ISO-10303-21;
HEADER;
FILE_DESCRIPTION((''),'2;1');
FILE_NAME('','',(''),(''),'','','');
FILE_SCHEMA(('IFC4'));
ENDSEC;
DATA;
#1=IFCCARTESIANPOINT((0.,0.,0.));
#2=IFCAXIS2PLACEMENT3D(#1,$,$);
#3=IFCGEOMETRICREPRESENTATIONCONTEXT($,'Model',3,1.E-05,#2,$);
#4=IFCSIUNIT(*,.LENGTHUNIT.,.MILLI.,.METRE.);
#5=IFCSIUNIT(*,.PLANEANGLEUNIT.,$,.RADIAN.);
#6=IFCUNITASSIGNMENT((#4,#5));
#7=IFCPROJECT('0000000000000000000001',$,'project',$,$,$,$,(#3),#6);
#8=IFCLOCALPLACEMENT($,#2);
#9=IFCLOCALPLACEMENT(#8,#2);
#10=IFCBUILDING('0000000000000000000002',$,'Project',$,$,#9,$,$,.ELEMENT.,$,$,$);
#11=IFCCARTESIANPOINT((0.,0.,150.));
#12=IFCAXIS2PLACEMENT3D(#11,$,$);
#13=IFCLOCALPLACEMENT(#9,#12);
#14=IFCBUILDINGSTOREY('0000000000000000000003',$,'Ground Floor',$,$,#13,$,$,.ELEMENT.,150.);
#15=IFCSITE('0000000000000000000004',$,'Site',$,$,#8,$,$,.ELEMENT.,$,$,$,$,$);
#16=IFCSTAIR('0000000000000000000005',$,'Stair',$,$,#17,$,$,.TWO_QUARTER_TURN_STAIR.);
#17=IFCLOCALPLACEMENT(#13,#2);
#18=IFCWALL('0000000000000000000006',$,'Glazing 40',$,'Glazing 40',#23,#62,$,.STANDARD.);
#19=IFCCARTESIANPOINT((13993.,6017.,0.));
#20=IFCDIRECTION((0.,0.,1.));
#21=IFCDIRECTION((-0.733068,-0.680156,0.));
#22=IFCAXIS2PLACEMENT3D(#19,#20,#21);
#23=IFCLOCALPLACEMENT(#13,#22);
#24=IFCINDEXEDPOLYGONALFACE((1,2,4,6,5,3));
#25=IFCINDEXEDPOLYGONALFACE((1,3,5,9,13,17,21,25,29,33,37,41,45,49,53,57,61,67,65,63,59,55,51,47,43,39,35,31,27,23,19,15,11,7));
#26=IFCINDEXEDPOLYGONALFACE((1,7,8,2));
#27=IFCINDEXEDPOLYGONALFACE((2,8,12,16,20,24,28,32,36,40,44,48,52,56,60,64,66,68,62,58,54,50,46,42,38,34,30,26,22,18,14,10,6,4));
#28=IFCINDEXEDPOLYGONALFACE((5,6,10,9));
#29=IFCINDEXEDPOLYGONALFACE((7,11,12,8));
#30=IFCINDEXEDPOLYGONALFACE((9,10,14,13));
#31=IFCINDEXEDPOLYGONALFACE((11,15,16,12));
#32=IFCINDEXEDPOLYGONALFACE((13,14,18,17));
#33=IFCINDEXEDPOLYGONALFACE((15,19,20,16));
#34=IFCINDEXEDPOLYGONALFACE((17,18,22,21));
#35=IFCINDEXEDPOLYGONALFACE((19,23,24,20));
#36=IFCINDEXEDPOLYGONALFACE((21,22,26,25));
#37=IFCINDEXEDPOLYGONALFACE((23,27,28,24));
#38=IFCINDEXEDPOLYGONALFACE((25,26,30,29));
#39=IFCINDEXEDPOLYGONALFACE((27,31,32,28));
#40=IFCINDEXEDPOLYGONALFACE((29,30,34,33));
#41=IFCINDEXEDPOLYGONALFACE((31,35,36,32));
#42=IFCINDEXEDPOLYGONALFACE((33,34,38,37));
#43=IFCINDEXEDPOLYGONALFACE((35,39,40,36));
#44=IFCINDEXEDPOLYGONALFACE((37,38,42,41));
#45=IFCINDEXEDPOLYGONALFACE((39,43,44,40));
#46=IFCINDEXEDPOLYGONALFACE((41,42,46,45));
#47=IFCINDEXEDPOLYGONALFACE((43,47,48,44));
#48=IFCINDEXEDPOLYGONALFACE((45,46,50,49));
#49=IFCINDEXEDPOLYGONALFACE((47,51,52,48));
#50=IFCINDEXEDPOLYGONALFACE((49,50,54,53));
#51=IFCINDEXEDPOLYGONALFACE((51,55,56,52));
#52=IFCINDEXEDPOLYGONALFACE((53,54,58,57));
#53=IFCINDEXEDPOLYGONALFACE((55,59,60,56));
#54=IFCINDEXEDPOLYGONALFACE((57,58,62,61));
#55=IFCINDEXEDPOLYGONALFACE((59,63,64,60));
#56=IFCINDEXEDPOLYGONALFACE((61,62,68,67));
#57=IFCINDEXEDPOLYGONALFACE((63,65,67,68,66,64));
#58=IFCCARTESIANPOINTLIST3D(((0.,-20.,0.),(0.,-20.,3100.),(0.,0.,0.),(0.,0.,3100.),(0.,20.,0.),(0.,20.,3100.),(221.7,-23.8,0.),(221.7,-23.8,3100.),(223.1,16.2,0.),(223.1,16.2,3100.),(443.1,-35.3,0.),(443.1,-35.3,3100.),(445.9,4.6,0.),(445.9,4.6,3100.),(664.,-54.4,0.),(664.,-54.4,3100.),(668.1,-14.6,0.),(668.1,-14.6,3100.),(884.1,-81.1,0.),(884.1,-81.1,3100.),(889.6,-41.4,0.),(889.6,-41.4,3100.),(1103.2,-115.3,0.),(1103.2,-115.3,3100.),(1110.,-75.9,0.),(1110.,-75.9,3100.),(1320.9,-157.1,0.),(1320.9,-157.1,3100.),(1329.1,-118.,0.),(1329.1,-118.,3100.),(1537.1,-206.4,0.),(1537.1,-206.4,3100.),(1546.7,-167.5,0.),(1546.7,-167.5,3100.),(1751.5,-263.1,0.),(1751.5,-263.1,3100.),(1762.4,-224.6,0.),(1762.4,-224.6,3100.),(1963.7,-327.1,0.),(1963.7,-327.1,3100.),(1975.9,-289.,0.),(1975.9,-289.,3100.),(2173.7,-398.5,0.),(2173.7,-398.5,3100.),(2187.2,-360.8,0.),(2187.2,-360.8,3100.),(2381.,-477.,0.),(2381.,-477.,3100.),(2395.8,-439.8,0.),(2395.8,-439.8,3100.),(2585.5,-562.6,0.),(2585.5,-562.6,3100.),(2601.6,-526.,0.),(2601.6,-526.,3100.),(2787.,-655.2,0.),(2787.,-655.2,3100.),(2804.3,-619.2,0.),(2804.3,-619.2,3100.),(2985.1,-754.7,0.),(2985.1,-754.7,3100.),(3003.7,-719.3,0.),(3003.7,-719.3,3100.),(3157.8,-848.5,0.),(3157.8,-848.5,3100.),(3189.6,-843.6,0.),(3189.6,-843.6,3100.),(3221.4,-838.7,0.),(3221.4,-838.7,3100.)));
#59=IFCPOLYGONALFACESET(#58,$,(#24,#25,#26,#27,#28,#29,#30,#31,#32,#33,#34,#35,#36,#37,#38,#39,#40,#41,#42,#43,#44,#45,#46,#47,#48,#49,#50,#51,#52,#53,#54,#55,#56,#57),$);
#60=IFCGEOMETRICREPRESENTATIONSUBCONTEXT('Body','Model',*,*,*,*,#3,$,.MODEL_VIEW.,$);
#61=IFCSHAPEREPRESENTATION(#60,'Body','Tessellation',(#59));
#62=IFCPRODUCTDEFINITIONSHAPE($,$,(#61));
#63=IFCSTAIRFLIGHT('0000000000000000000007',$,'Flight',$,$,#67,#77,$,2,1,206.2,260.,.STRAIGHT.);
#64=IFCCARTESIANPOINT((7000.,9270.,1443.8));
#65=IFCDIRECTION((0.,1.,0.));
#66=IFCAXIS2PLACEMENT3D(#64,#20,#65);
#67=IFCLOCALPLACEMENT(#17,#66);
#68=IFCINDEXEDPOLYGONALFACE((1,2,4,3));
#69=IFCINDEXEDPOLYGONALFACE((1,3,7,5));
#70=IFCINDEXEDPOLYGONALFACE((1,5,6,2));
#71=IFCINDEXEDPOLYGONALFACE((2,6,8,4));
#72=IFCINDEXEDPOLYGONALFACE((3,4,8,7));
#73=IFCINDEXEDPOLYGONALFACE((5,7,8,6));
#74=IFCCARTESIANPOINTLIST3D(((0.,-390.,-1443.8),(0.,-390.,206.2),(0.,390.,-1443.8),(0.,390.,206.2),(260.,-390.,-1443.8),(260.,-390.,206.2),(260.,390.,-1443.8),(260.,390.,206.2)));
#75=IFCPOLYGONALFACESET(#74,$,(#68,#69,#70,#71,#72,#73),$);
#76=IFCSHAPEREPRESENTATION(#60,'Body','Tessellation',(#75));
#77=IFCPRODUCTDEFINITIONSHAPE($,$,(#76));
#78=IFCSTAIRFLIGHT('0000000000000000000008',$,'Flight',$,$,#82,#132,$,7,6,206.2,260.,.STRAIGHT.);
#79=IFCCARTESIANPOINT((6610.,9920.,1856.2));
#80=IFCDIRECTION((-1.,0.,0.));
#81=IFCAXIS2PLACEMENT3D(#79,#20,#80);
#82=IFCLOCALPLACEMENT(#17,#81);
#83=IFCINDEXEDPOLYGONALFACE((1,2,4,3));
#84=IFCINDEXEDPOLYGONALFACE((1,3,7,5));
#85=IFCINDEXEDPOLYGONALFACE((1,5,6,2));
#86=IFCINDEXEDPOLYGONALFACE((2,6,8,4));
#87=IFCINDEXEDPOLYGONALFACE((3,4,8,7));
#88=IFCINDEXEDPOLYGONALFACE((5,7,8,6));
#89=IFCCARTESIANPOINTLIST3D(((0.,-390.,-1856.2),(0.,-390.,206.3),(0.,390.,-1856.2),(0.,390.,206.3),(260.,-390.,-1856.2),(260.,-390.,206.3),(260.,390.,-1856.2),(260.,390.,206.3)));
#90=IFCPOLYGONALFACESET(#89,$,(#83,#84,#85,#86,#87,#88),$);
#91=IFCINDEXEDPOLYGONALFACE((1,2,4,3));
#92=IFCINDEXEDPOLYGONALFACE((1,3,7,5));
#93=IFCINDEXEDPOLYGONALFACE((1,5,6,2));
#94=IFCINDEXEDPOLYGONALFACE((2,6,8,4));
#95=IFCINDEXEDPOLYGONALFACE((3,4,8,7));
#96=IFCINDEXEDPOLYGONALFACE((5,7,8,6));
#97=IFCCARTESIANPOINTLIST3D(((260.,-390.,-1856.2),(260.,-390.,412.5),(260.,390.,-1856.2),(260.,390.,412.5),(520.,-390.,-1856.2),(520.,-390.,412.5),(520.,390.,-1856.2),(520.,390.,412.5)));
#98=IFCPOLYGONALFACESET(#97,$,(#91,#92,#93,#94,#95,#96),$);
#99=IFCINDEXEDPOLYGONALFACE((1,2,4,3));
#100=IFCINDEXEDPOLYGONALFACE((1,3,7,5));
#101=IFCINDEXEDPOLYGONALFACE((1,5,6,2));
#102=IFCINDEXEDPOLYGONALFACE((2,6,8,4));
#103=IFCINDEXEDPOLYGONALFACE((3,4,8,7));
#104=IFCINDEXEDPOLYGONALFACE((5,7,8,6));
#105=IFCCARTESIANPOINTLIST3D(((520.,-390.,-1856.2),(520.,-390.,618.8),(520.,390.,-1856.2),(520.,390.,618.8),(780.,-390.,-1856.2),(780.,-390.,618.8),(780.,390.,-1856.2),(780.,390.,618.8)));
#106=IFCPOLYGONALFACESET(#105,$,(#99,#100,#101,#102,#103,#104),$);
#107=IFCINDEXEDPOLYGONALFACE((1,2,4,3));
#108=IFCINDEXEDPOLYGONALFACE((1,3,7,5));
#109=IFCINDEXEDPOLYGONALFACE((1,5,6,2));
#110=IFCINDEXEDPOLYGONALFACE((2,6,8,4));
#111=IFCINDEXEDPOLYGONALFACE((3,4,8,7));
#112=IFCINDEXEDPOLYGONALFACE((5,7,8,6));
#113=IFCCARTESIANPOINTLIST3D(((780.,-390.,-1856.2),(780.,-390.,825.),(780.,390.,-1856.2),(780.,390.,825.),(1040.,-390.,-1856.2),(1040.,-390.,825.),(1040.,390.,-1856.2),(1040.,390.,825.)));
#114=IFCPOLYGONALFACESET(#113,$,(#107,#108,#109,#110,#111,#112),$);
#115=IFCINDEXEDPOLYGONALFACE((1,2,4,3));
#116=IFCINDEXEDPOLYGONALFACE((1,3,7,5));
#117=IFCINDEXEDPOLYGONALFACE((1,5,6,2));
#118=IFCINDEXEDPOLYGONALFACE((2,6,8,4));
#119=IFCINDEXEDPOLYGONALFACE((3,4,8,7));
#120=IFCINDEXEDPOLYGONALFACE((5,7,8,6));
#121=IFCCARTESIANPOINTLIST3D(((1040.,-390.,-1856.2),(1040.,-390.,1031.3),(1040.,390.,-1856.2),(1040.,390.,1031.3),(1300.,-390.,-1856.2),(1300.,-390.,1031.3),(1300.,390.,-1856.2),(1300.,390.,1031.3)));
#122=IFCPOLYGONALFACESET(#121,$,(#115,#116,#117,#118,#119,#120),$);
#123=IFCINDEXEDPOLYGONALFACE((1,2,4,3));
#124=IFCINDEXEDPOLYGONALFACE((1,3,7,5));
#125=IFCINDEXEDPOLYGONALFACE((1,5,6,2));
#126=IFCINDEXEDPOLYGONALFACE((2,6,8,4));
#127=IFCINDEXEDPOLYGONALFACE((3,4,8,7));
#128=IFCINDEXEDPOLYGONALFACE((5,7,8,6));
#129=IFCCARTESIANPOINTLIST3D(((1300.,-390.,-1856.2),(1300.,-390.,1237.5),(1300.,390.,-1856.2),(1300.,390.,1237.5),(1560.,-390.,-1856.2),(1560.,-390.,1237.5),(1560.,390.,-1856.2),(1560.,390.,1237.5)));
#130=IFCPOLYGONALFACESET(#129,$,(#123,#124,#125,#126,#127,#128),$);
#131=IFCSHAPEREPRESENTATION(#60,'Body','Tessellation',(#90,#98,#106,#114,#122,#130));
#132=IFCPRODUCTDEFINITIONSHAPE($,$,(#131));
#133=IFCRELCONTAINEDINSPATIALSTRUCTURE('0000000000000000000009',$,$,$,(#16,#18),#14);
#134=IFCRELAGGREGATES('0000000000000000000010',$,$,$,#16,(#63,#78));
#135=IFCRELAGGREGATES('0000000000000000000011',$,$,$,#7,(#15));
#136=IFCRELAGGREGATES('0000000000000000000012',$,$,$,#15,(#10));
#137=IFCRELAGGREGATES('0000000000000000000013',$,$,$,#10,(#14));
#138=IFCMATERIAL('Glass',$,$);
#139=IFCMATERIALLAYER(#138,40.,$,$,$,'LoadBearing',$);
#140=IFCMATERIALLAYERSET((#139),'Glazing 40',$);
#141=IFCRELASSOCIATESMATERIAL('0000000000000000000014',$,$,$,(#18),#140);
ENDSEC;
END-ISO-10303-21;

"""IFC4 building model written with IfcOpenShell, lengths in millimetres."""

from ifc_helpers import new_model, si_unit, frame, frame_2d, origin, place, context, subcontext, project, spatial, polyline, rectangle, outline, extrude, material, layer, layer_set, layer_usage, element, aggregate, save


model = new_model("IFC4")

# Units and contexts
model_context = context("Model", 3, precision=1e-05, world=origin())
body_context = subcontext(model_context, "Body", "Model", "MODEL_VIEW")
ifc_project = project(units=[si_unit("LENGTHUNIT", "METRE", prefix="MILLI"), si_unit("PLANEANGLEUNIT", "RADIAN")], contexts=[model_context])

# Site, building, storey
site_placement = place(None, origin())
site = spatial("IfcSite", under=ifc_project, at=site_placement, Name="Site", CompositionType="ELEMENT")
building_placement = place(site_placement, origin())
building = spatial("IfcBuilding", under=site, at=building_placement, Name="Project", CompositionType="ELEMENT")
storey_placement = place(building_placement, frame((0.0, 0.0, 150.0)))
storey = spatial("IfcBuildingStorey", under=building, at=storey_placement, Name="Ground Floor", CompositionType="ELEMENT", Elevation=150.0)

# Stair
stair_placement = place(storey_placement, origin())
stair = element("IfcStair", 1, at=stair_placement, inside=storey, Name="Stair", PredefinedType="TWO_QUARTER_TURN_STAIR")

# Wall
ifc_material_1 = material(Name="Glass")
ifc_layer_1 = layer(ifc_material_1, 40.0, Category="LoadBearing")
ifc_layer_set_1 = layer_set([ifc_layer_1], Name="Glazing 40")
ifc_layer_usage_1 = layer_usage(ifc_layer_set_1, "AXIS2", "NEGATIVE", 20.0)
wall_1_placement = place(storey_placement, frame((13993.0, 6017.0, 0.0), z_axis=(0.0, 0.0, 1.0), x_axis=(-0.733068, -0.680156, 0.0)))
element("IfcWall", 2, at=wall_1_placement, inside=storey, material=ifc_layer_usage_1, Name="Glazing 40", ObjectType="Glazing 40", PredefinedType="STANDARD", context=body_context, shape_type="SweptSolid", body=[
    extrude(outline(polyline([(0.0, -20.0), (0.0, 0.0), (0.0, 20.0), (223.1, 16.2), (445.9, 4.6), (668.1, -14.6), (889.6, -41.4), (1110.0, -75.9), (1329.1, -118.0), (1546.7, -167.5), (1762.4, -224.6), (1975.9, -289.0), (2187.2, -360.8), (2395.8, -439.8), (2601.6, -526.0), (2804.3, -619.2), (3003.7, -719.3), (3221.4, -838.7), (3189.6, -843.6), (3157.8, -848.5), (2985.1, -754.7), (2787.0, -655.2), (2585.5, -562.6), (2381.0, -477.0), (2173.7, -398.5), (1963.7, -327.1), (1751.5, -263.1), (1537.1, -206.4), (1320.9, -157.1), (1103.2, -115.3), (884.1, -81.1), (664.0, -54.4), (443.1, -35.3), (221.7, -23.8), (0.0, -20.0)])), origin(), (0.0, 0.0, 1.0), 3100.0),
])

# Stair flights
stair_flight_1_placement = place(stair_placement, frame((7000.0, 9270.0, 1443.8), z_axis=(0.0, 0.0, 1.0), x_axis=(0.0, 1.0, 0.0)))
stair_flight_1 = element("IfcStairFlight", 3, at=stair_flight_1_placement, Name="Flight", NumberOfRisers=2, NumberOfTreads=1, PredefinedType="STRAIGHT", RiserHeight=206.2, TreadLength=260.0, context=body_context, shape_type="SweptSolid", body=[
    extrude(rectangle(XDim=260.0, YDim=780.0, at=frame_2d((130.0, 0.0))), frame((0.0, 0.0, -1443.8)), (0.0, 0.0, 1.0), 1650.0),
])
stair_flight_2_placement = place(stair_placement, frame((6610.0, 9920.0, 1856.2), z_axis=(0.0, 0.0, 1.0), x_axis=(-1.0, 0.0, 0.0)))
stair_flight_2 = element("IfcStairFlight", 4, at=stair_flight_2_placement, Name="Flight", NumberOfRisers=7, NumberOfTreads=6, PredefinedType="STRAIGHT", RiserHeight=206.2, TreadLength=260.0, context=body_context, shape_type="SweptSolid", body=[
    extrude(rectangle(XDim=260.0, YDim=780.0, at=frame_2d((130.0, 0.0))), frame((0.0, 0.0, -1856.2)), (0.0, 0.0, 1.0), 2062.5),
    extrude(rectangle(XDim=260.0, YDim=780.0, at=frame_2d((390.0, 0.0))), frame((0.0, 0.0, -1856.2)), (0.0, 0.0, 1.0), 2268.8),
    extrude(rectangle(XDim=260.0, YDim=780.0, at=frame_2d((650.0, 0.0))), frame((0.0, 0.0, -1856.2)), (0.0, 0.0, 1.0), 2475.0),
    extrude(rectangle(XDim=260.0, YDim=780.0, at=frame_2d((910.0, 0.0))), frame((0.0, 0.0, -1856.2)), (0.0, 0.0, 1.0), 2681.2),
    extrude(rectangle(XDim=260.0, YDim=780.0, at=frame_2d((1170.0, 0.0))), frame((0.0, 0.0, -1856.2)), (0.0, 0.0, 1.0), 2887.5),
    extrude(rectangle(XDim=260.0, YDim=780.0, at=frame_2d((1430.0, 0.0))), frame((0.0, 0.0, -1856.2)), (0.0, 0.0, 1.0), 3093.8),
])
aggregate(stair, [stair_flight_1, stair_flight_2])

save(model, "model.ifc")
